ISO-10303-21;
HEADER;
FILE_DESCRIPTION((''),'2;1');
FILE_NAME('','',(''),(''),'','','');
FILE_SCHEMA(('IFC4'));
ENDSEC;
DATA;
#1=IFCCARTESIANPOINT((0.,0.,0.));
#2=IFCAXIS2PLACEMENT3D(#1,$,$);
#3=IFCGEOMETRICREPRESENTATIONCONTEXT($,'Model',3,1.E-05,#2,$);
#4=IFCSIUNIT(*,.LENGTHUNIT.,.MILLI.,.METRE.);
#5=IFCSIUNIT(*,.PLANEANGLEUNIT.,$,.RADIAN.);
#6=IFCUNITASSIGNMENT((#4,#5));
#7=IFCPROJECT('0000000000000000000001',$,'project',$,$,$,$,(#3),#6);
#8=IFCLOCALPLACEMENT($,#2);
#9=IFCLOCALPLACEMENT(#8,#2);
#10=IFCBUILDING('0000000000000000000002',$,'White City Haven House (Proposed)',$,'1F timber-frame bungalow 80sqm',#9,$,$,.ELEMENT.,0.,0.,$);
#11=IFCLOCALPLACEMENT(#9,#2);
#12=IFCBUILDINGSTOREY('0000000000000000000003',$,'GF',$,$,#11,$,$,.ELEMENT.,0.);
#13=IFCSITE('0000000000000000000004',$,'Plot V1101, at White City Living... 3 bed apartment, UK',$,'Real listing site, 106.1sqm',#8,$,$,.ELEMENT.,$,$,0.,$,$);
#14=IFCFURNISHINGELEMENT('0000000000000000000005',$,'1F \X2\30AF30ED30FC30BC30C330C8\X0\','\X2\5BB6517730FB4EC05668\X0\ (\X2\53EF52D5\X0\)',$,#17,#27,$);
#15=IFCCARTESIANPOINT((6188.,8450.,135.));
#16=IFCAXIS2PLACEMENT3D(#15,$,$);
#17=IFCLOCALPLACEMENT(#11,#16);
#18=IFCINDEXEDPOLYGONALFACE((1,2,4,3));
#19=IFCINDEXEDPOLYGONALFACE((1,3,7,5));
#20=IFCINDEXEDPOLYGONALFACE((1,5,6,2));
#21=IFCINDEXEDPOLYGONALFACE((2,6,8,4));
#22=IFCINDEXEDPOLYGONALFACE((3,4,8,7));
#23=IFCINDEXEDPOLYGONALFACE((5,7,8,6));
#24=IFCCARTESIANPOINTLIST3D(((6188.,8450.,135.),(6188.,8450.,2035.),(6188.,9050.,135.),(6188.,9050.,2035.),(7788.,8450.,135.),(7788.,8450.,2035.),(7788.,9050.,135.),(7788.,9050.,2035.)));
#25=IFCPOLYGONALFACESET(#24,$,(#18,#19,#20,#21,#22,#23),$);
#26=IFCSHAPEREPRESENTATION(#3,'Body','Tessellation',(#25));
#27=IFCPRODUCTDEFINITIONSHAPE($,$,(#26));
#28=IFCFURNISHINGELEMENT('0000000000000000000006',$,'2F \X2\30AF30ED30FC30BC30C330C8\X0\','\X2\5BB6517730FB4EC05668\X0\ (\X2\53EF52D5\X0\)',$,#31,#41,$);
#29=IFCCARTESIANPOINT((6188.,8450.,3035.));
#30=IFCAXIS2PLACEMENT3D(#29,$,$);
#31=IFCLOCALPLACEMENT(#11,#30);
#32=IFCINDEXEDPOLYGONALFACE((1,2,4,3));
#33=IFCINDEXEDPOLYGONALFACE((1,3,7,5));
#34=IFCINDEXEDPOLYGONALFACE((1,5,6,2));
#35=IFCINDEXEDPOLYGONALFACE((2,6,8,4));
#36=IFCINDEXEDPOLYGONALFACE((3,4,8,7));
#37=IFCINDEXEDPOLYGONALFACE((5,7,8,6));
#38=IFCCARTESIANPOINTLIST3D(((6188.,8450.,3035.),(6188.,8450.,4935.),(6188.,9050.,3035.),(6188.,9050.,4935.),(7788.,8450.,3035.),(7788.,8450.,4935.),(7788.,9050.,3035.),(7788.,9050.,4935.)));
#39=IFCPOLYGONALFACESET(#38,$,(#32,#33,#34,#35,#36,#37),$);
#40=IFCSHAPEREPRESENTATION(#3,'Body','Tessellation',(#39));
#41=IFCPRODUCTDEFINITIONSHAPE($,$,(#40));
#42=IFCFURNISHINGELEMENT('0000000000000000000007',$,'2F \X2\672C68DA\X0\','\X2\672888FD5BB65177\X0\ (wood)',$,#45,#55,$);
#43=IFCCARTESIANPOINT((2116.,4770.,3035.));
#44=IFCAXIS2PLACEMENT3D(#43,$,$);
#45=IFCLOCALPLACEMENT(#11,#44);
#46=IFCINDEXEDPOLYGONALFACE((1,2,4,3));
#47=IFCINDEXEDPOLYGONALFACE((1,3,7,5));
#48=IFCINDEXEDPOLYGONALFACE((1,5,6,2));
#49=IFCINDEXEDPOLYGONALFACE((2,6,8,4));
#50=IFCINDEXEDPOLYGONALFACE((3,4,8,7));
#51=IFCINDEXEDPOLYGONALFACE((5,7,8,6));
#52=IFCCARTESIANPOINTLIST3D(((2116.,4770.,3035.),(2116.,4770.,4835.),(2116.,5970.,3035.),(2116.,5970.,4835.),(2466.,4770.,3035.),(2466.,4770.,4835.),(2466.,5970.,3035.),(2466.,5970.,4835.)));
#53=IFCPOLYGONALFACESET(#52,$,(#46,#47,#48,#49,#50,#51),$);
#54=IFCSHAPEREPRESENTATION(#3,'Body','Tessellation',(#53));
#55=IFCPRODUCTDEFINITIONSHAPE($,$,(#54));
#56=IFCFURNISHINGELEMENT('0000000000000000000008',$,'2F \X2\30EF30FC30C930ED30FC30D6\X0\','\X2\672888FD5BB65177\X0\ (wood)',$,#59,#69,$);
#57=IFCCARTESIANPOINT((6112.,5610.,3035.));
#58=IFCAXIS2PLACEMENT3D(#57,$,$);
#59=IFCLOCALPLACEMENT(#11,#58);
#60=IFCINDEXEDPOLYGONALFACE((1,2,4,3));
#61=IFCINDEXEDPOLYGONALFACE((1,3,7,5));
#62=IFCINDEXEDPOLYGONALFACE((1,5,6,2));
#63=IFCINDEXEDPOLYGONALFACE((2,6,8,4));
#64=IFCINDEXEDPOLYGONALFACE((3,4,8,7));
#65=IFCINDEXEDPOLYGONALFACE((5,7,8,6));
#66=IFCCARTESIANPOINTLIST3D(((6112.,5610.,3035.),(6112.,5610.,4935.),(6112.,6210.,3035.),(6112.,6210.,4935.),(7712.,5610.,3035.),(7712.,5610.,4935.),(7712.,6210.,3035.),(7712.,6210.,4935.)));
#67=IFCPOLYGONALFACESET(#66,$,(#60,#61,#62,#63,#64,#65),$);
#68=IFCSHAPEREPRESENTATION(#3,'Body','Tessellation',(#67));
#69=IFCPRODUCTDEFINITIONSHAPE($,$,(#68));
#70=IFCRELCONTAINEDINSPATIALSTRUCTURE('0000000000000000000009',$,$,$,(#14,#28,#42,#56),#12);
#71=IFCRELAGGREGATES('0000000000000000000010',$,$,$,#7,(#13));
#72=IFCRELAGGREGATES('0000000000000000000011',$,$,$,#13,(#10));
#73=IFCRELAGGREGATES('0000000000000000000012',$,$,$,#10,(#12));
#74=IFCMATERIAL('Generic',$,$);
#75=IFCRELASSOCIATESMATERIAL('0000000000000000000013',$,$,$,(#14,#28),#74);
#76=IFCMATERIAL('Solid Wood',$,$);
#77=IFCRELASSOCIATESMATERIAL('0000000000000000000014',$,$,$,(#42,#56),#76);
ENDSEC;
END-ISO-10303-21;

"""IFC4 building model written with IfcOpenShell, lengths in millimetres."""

from ifc_helpers import new_model, si_unit, frame, frame_2d, origin, place, context, project, spatial, rectangle, extrude, material, element, save


model = new_model("IFC4")

# Units and contexts
model_context = context("Model", 3, precision=1e-05, world=origin())
ifc_project = project(units=[si_unit("LENGTHUNIT", "METRE", prefix="MILLI"), si_unit("PLANEANGLEUNIT", "RADIAN")], contexts=[model_context])

# Site, building, storey
site_placement = place(None, origin())
site = spatial("IfcSite", under=ifc_project, at=site_placement, Name="Plot V1101, at White City Living... 3 bed apartment, UK", ObjectType="Real listing site, 106.1sqm", CompositionType="ELEMENT", RefElevation=0.0)
building_placement = place(site_placement, origin())
building = spatial("IfcBuilding", under=site, at=building_placement, Name="White City Haven House (Proposed)", ObjectType="1F timber-frame bungalow 80sqm", CompositionType="ELEMENT", ElevationOfRefHeight=0.0, ElevationOfTerrain=0.0)
storey_placement = place(building_placement, origin())
storey = spatial("IfcBuildingStorey", under=building, at=storey_placement, Name="GF", CompositionType="ELEMENT", Elevation=0.0)

# Shared definitions
ifc_material_1 = material(Name="Solid Wood")

# Shared definitions
ifc_material_2 = material(Name="Generic")

# Furnishing elements
furnishing_1_placement = place(storey_placement, frame((6188.0, 8450.0, 135.0)))
element("IfcFurnishingElement", 1, at=furnishing_1_placement, inside=storey, material=ifc_material_2, Name="1F クローゼット", Description="家具・什器 (可動)", context=model_context, shape_type="SweptSolid", body=[
    extrude(rectangle(XDim=1600.0, YDim=600.0, at=frame_2d((800.0, 300.0))), frame((6188.0, 8450.0, 135.0)), (0.0, 0.0, 1.0), 1900.0),
])
furnishing_2_placement = place(storey_placement, frame((6188.0, 8450.0, 3035.0)))
element("IfcFurnishingElement", 2, at=furnishing_2_placement, inside=storey, material=ifc_material_2, Name="2F クローゼット", Description="家具・什器 (可動)", context=model_context, shape_type="SweptSolid", body=[
    extrude(rectangle(XDim=1600.0, YDim=600.0, at=frame_2d((800.0, 300.0))), frame((6188.0, 8450.0, 3035.0)), (0.0, 0.0, 1.0), 1900.0),
])
furnishing_3_placement = place(storey_placement, frame((2116.0, 4770.0, 3035.0)))
element("IfcFurnishingElement", 3, at=furnishing_3_placement, inside=storey, material=ifc_material_1, Name="2F 本棚", Description="木製家具 (wood)", context=model_context, shape_type="SweptSolid", body=[
    extrude(rectangle(XDim=350.0, YDim=1200.0, at=frame_2d((175.0, 600.0))), frame((2116.0, 4770.0, 3035.0)), (0.0, 0.0, 1.0), 1800.0),
])
furnishing_4_placement = place(storey_placement, frame((6112.0, 5610.0, 3035.0)))
element("IfcFurnishingElement", 4, at=furnishing_4_placement, inside=storey, material=ifc_material_1, Name="2F ワードローブ", Description="木製家具 (wood)", context=model_context, shape_type="SweptSolid", body=[
    extrude(rectangle(XDim=1600.0, YDim=600.0, at=frame_2d((800.0, 300.0))), frame((6112.0, 5610.0, 3035.0)), (0.0, 0.0, 1.0), 1900.0),
])

save(model, "model.ifc")
